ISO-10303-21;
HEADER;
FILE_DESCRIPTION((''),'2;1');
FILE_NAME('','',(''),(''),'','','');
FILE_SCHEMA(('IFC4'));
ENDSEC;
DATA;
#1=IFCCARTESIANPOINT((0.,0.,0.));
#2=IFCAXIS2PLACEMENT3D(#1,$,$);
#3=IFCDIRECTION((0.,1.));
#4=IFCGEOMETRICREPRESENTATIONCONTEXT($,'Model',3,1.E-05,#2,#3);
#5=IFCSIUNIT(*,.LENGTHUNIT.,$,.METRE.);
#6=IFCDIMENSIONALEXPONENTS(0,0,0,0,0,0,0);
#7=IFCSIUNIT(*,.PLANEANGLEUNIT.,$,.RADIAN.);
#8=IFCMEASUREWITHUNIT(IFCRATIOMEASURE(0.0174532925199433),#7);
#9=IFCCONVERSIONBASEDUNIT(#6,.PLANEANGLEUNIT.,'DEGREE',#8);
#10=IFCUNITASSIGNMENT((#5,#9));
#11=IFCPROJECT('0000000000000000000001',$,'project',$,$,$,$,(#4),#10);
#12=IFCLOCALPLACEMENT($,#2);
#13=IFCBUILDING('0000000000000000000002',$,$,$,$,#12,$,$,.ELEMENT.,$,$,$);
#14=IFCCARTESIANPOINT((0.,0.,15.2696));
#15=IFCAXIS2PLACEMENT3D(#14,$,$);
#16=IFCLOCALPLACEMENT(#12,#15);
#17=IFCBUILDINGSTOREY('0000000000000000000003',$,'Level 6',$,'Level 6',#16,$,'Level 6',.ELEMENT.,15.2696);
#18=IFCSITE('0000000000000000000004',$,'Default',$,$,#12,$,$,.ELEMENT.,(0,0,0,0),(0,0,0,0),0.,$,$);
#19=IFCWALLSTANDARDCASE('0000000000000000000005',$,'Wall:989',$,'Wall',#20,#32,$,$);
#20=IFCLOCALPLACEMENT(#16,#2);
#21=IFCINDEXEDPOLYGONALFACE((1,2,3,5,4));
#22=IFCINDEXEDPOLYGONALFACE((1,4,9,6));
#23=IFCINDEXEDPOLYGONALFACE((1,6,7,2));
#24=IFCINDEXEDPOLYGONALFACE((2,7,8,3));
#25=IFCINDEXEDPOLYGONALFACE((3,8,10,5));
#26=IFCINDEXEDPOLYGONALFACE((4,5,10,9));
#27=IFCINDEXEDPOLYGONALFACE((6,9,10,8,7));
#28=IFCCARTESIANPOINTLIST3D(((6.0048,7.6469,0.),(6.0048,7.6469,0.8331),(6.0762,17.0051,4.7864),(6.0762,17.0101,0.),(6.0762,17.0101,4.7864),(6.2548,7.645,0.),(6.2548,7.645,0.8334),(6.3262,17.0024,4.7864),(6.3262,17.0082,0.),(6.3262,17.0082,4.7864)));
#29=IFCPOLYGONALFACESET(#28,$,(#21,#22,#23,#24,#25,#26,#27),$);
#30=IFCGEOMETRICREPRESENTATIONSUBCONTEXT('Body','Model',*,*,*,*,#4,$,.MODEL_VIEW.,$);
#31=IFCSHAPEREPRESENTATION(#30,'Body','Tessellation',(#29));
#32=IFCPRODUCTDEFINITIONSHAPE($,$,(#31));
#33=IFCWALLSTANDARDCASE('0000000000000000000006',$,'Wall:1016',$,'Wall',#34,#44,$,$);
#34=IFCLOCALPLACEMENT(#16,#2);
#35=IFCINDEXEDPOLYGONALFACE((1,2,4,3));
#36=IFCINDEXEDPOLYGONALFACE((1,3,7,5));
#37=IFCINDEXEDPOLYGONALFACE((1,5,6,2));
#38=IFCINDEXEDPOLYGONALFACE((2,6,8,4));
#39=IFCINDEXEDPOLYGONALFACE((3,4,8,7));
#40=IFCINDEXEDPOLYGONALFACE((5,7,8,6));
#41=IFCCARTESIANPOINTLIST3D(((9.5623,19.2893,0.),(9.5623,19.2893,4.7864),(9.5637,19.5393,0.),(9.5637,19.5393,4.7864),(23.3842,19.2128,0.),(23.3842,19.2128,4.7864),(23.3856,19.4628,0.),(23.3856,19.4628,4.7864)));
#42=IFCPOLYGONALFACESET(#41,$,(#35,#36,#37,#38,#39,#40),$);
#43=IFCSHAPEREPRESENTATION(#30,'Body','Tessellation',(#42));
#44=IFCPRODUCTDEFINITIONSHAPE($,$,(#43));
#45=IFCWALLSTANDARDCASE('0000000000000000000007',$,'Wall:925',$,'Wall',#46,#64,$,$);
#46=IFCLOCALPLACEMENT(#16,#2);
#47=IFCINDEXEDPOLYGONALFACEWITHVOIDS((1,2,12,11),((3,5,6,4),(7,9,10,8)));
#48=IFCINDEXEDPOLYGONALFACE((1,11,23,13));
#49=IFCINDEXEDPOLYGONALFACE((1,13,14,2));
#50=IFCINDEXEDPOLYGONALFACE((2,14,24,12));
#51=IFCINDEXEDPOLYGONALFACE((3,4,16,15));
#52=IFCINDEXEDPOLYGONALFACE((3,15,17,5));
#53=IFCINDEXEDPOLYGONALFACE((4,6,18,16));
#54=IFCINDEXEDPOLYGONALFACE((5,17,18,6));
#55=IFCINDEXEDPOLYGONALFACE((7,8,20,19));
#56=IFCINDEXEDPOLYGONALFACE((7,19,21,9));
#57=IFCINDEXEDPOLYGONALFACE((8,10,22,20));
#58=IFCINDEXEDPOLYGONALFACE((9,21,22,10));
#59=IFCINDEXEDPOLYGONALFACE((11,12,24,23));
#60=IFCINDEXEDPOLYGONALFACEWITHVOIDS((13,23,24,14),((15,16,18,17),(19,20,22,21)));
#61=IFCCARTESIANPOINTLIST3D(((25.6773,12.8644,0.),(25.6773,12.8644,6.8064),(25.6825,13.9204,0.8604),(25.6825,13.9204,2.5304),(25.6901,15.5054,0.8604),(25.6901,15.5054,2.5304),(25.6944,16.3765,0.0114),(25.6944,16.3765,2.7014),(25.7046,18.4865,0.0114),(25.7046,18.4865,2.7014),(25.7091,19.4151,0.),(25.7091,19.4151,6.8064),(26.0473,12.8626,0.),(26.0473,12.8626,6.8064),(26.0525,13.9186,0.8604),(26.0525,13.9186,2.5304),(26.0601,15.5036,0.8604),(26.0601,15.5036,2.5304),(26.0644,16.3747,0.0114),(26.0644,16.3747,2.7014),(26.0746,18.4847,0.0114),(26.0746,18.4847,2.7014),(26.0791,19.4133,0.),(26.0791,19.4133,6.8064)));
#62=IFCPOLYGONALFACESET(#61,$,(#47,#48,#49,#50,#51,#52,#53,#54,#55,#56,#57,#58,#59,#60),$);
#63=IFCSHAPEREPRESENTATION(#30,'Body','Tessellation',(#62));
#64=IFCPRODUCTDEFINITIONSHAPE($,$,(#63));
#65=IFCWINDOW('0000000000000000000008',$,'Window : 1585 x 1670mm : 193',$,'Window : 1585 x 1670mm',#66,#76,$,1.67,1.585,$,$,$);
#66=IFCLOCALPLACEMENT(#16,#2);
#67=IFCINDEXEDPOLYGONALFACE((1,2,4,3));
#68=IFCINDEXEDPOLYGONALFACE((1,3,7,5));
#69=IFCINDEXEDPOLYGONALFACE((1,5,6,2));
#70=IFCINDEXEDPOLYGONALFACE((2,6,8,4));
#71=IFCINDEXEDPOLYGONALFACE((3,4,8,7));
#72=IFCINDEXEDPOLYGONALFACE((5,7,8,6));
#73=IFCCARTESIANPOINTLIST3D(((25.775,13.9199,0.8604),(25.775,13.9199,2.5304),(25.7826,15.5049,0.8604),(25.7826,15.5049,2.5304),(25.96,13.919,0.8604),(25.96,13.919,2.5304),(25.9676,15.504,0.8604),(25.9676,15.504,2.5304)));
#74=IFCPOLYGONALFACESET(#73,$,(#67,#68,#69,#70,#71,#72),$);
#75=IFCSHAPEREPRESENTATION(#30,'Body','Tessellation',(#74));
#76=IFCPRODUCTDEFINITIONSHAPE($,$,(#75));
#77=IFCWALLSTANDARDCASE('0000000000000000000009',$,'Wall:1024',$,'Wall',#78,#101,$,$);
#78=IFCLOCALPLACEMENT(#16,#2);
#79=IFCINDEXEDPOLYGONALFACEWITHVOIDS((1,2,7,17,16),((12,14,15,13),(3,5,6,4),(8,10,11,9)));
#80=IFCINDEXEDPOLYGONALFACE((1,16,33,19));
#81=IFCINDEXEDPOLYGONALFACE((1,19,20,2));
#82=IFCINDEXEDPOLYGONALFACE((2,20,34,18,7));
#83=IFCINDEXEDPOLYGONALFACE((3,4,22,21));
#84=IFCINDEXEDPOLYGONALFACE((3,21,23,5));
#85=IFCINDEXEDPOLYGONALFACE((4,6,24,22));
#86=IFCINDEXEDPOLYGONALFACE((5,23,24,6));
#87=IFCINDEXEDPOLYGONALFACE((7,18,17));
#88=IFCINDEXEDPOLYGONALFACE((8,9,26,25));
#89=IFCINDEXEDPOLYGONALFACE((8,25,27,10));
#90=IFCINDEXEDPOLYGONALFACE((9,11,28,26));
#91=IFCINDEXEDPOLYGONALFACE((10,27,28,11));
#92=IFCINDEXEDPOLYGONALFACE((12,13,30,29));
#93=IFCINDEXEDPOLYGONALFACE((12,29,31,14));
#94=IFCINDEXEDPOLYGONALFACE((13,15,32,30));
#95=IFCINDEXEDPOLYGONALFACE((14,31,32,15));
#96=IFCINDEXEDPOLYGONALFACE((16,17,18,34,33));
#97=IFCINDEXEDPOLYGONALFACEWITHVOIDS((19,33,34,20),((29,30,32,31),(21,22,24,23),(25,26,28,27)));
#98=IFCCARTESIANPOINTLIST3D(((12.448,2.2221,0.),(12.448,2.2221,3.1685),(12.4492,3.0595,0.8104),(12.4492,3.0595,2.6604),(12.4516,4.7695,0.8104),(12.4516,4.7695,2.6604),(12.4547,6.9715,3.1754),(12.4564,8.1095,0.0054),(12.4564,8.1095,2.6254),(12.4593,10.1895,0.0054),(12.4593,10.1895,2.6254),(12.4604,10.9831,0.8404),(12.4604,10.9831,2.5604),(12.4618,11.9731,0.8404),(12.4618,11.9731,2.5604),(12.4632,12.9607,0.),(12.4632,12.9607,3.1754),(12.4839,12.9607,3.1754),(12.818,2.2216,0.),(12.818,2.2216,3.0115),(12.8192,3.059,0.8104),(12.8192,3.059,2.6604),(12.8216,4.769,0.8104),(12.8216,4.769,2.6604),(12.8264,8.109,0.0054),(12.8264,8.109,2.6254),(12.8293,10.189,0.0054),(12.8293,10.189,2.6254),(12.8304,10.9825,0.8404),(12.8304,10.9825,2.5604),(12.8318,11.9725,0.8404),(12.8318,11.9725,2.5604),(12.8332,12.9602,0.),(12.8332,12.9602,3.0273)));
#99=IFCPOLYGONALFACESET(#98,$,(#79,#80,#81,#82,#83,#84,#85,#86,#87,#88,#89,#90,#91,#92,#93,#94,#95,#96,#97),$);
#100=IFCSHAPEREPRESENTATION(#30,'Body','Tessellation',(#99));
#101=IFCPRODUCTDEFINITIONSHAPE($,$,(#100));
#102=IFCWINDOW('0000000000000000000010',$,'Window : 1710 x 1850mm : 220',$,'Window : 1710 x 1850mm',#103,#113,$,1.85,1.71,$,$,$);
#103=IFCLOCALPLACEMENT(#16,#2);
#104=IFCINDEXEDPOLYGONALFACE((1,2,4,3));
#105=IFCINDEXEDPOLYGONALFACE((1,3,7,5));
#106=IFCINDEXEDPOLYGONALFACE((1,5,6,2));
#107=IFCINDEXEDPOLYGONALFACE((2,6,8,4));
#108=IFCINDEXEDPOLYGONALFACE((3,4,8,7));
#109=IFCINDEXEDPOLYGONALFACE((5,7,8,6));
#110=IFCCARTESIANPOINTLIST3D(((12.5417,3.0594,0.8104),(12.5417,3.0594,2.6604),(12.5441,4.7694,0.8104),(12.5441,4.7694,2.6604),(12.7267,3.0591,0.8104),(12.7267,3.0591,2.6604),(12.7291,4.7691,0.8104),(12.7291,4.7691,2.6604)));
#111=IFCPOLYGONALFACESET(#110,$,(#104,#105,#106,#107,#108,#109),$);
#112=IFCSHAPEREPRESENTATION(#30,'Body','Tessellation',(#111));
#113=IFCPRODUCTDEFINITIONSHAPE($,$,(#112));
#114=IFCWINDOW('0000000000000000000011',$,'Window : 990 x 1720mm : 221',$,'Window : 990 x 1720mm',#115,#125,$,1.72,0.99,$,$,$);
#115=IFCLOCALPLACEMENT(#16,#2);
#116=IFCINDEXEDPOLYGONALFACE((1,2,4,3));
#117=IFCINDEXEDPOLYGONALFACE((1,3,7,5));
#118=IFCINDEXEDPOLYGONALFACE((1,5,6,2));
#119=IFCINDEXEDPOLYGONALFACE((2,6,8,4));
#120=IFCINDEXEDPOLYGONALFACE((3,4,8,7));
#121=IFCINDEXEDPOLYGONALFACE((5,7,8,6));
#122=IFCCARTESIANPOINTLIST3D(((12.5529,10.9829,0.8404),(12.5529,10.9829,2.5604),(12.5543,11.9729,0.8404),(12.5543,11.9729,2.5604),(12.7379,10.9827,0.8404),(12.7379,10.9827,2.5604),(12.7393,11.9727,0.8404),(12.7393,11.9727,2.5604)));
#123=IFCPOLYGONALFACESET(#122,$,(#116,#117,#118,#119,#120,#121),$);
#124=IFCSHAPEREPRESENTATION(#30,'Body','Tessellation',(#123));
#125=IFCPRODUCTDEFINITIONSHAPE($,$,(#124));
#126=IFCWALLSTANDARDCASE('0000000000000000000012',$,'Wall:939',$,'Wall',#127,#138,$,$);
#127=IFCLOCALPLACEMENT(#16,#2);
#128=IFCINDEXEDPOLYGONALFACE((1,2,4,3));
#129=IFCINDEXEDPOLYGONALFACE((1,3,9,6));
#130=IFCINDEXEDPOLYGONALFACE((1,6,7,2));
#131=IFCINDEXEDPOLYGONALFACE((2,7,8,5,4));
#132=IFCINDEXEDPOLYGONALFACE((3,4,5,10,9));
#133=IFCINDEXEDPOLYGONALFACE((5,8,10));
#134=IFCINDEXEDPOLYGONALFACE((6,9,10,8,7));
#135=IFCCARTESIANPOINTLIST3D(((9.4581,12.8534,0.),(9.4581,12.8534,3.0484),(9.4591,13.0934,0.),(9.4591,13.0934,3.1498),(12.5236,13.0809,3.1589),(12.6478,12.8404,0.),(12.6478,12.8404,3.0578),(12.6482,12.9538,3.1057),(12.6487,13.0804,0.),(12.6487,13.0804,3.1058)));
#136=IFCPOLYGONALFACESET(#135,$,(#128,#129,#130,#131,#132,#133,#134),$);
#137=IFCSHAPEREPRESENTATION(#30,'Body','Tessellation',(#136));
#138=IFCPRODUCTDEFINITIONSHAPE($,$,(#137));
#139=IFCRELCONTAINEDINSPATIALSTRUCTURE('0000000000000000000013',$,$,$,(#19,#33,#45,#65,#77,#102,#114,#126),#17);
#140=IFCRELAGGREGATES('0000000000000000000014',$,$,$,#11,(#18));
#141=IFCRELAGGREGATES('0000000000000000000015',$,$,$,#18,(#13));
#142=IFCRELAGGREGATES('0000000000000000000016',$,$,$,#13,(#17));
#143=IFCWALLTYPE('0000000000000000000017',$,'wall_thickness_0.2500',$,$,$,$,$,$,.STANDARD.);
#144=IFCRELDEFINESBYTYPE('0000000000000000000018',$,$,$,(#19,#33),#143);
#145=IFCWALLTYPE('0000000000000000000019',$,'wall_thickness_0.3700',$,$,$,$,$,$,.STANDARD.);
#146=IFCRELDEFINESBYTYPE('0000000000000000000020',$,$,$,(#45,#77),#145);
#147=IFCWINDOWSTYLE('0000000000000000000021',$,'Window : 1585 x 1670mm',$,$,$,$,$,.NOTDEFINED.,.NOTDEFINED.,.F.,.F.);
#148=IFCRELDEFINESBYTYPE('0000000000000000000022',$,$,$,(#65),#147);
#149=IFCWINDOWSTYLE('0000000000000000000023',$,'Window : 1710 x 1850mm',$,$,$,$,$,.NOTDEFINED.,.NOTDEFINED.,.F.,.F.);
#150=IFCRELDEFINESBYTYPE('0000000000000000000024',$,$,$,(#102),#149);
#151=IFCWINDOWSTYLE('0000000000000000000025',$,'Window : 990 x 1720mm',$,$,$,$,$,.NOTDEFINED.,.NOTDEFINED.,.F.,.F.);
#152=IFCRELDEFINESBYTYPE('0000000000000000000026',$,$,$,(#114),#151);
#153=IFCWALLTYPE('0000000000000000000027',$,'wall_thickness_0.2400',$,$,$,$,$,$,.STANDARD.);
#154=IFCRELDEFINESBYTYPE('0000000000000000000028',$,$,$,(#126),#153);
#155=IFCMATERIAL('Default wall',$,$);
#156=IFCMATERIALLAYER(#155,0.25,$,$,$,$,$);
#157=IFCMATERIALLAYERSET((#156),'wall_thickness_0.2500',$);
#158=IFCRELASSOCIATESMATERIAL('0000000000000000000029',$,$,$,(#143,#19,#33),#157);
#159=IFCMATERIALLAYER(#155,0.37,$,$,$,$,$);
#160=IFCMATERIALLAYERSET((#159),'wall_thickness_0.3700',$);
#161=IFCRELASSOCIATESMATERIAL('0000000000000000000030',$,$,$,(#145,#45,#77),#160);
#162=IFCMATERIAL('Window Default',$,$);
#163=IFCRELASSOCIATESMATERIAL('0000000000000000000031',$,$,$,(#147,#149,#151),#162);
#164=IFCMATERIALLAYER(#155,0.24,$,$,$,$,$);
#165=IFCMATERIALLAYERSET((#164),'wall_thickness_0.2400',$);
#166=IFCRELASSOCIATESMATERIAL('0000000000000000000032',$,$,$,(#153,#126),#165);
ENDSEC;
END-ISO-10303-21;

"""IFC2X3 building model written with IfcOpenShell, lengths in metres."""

from ifc_helpers import new_model, entity, si_unit, converted_unit, direction, frame, frame_2d, origin, origin_2d_with_axis, place, context, subcontext, project, spatial, polyline, rectangle, outline, extrude, clip, halfspace, source, transform, mapped, material, layer, layer_set, layer_usage, type_object, type_shapes, element, fill, save


model = new_model("IFC2X3")

# Units and contexts
model_context = context("Model", 3, precision=1e-05, world=origin(), true_north=direction((0.0, 1.0)))
body_context = subcontext(model_context, "Body", "Model", "MODEL_VIEW")
ifc_project = project(units=[si_unit("LENGTHUNIT", "METRE"), converted_unit("PLANEANGLEUNIT", "DEGREE", entity("IfcRatioMeasure", 0.0174532925199433), si_unit("PLANEANGLEUNIT", "RADIAN"), dimensions=[0, 0, 0, 0, 0, 0, 0])], contexts=[model_context])

# Site, building, storey
placement = place(None, origin())
site = spatial("IfcSite", under=ifc_project, at=placement, Name="Default", CompositionType="ELEMENT", RefLatitude=(0, 0, 0, 0), RefLongitude=(0, 0, 0, 0), RefElevation=0.0)
building = spatial("IfcBuilding", under=site, at=placement, CompositionType="ELEMENT")
storey_placement = place(placement, frame((0.0, 0.0, 15.2696)))
storey = spatial("IfcBuildingStorey", under=building, at=storey_placement, Name="Level 6", ObjectType="Level 6", LongName="Level 6", CompositionType="ELEMENT", Elevation=15.2696)

# Walls
ifc_material_1 = material(Name="Default wall")
ifc_layer_1 = layer(ifc_material_1, 0.25)
ifc_layer_set_1 = layer_set([ifc_layer_1], Name="wall_thickness_0.2500")
ifc_layer_usage_1 = layer_usage(ifc_layer_set_1, "AXIS2", "POSITIVE", -0.125)
wall_type_1 = type_object("IfcWallType", Name="wall_thickness_0.2500", PredefinedType="STANDARD", material=ifc_layer_set_1)
wall_1_placement = place(storey_placement, frame((6.2012, 17.0092, 0.0), z_axis=(0.0, 0.0, 1.0), x_axis=(-0.007623, -0.999971, 0.0)))
element("IfcWallStandardCase", 1, at=wall_1_placement, inside=storey, type_object=wall_type_1, material=ifc_layer_usage_1, Name="Wall:989", ObjectType="Wall", context=body_context, shape_type="Clipping", body=[
    clip(clip(extrude(outline(polyline([(9.3635, -0.125), (9.3635, 0.125), (0.0, 0.125), (0.0, -0.125), (9.3635, -0.125)])), origin(), (0.0, 0.0, 1.0), 4.7864), halfspace(frame((-60.2827, 7.4216, 2.6304), z_axis=(-0.001073, 0.390504, 0.920601), x_axis=(0.003026, -0.920596, 0.390505)), False)), halfspace(frame((-2.4456, -18.2536, 5.7956), z_axis=(0.389138, -0.001325, 0.921178), x_axis=(0.002195, 0.999997, 0.000511)), False)),
])
wall_2_placement = place(storey_placement, frame((9.563, 19.4143, 0.0), z_axis=(0.0, 0.0, 1.0), x_axis=(0.999985, -0.005533, 0.0)))
element("IfcWallStandardCase", 2, at=wall_2_placement, inside=storey, type_object=wall_type_1, material=ifc_layer_usage_1, Name="Wall:1016", ObjectType="Wall", context=body_context, shape_type="Clipping", body=[
    clip(extrude(outline(polyline([(13.8221, -0.125), (13.8221, 0.125), (0.0, 0.125), (0.0, -0.125), (13.8221, -0.125)])), origin(), (0.0, 0.0, 1.0), 4.7864), halfspace(frame((14.8176, -0.096, 5.8902), z_axis=(0.001197, 0.389103, 0.921193), x_axis=(-0.999991, 0.004285, -0.000511)), False)),
])

# Wall, openings, window
ifc_layer_2 = layer(ifc_material_1, 0.37)
ifc_layer_set_2 = layer_set([ifc_layer_2], Name="wall_thickness_0.3700")
ifc_layer_usage_2 = layer_usage(ifc_layer_set_2, "AXIS2", "POSITIVE", -0.185)
wall_type_2 = type_object("IfcWallType", Name="wall_thickness_0.3700", PredefinedType="STANDARD", material=ifc_layer_set_2)
wall_3_placement = place(storey_placement, frame((25.8941, 19.4142, 0.0), z_axis=(0.0, 0.0, 1.0), x_axis=(-0.004844, -0.999988, 0.0)))
wall_3 = element("IfcWallStandardCase", 3, at=wall_3_placement, inside=storey, type_object=wall_type_2, material=ifc_layer_usage_2, Name="Wall:925", ObjectType="Wall", context=body_context, shape_type="SweptSolid", body=[
    extrude(outline(polyline([(6.5507, -0.185), (6.5507, 0.185), (0.0, 0.185), (0.0, -0.185), (6.5507, -0.185)])), origin(), (0.0, 0.0, 1.0), 6.8064),
])
opening_1_placement = place(wall_3_placement, frame((0.9286, -0.185, 0.0114)))
element("IfcOpeningElement", 4, at=opening_1_placement, cuts=wall_3, ObjectType="Opening", context=body_context, shape_type="SweptSolid", body=[
    extrude(rectangle(XDim=2.11, YDim=2.69, at=frame_2d((1.345, 1.055), x_axis=(0.0, 1.0))), frame((0.0, 0.0, 0.0), z_axis=(0.0, 1.0, 0.0), x_axis=(0.0, 0.0, 1.0)), (0.0, 0.0, 1.0), 0.37),
])
opening_2_placement = place(wall_3_placement, frame((3.9097, -0.185, 0.8604)))
opening_2 = element("IfcOpeningElement", 5, at=opening_2_placement, cuts=wall_3, ObjectType="Opening", context=body_context, shape_type="SweptSolid", body=[
    extrude(rectangle(XDim=1.585, YDim=1.67, at=frame_2d((0.835, 0.7925), x_axis=(0.0, 1.0))), frame((0.0, 0.0, 0.0), z_axis=(0.0, 1.0, 0.0), x_axis=(0.0, 0.0, 1.0)), (0.0, 0.0, 1.0), 0.37),
])
ifc_material_2 = material(Name="Window Default")
window_style_1 = type_object("IfcWindowStyle", Name="Window : 1585 x 1670mm", ConstructionType="NOTDEFINED", OperationType="NOTDEFINED", ParameterTakesPrecedence=False, Sizeable=False, material=ifc_material_2)
shared_shape_1 = source(origin(), body_context, "Body", "SweptSolid", [
    extrude(rectangle(XDim=0.185, YDim=1.585, at=origin_2d_with_axis()), frame((0.7925, 0.185, 0.0), z_axis=(0.0, 0.0, 1.0), x_axis=(0.0, 1.0, 0.0)), (0.0, 0.0, 1.0), 1.67),
])
type_shapes(window_style_1, [shared_shape_1])
window_1_placement = place(opening_2_placement, origin())
window_1 = element("IfcWindow", 6, at=window_1_placement, inside=storey, type_object=window_style_1, Name="Window : 1585 x 1670mm : 193", ObjectType="Window : 1585 x 1670mm", OverallHeight=1.67, OverallWidth=1.585, context=body_context, shape_type="MappedRepresentation", body=[
    mapped(shared_shape_1, transform((0.0, 0.0, 0.0), scale=1.0)),
])
fill(opening_2, window_1)

# Wall, openings, windows
wall_4_placement = place(storey_placement, frame((12.6482, 12.9604, 0.0), z_axis=(0.0, 0.0, 1.0), x_axis=(-0.001421, -0.999999, 0.0)))
wall_4 = element("IfcWallStandardCase", 7, at=wall_4_placement, inside=storey, type_object=wall_type_2, material=ifc_layer_usage_2, Name="Wall:1024", ObjectType="Wall", context=body_context, shape_type="Clipping", body=[
    clip(extrude(outline(polyline([(10.7386, -0.185), (10.7386, 0.185), (0.0, 0.185), (0.0, -0.185), (10.7386, -0.185)])), origin(), (0.0, 0.0, 1.0), 3.1754), halfspace(frame((-64.2751, 1.3426, 2.6304), z_axis=(0.001349, 0.390503, 0.920601), x_axis=(-0.002684, -0.920597, 0.390505)), False)),
])
opening_3_placement = place(wall_4_placement, frame((2.7712, -0.185, 0.0054)))
element("IfcOpeningElement", 8, at=opening_3_placement, cuts=wall_4, ObjectType="Opening", context=body_context, shape_type="SweptSolid", body=[
    extrude(rectangle(XDim=2.08, YDim=2.62, at=frame_2d((1.31, 1.04), x_axis=(0.0, 1.0))), frame((0.0, 0.0, 0.0), z_axis=(0.0, 1.0, 0.0), x_axis=(0.0, 0.0, 1.0)), (0.0, 0.0, 1.0), 0.37),
])
opening_4_placement = place(wall_4_placement, frame((8.1912, -0.185, 0.8104)))
opening_4 = element("IfcOpeningElement", 9, at=opening_4_placement, cuts=wall_4, ObjectType="Opening", context=body_context, shape_type="SweptSolid", body=[
    extrude(rectangle(XDim=1.71, YDim=1.85, at=frame_2d((0.925, 0.855), x_axis=(0.0, 1.0))), frame((0.0, 0.0, 0.0), z_axis=(0.0, 1.0, 0.0), x_axis=(0.0, 0.0, 1.0)), (0.0, 0.0, 1.0), 0.37),
])
opening_5_placement = place(wall_4_placement, frame((0.9876, -0.185, 0.8404)))
opening_5 = element("IfcOpeningElement", 10, at=opening_5_placement, cuts=wall_4, ObjectType="Opening", context=body_context, shape_type="SweptSolid", body=[
    extrude(rectangle(XDim=0.99, YDim=1.72, at=frame_2d((0.86, 0.495), x_axis=(0.0, 1.0))), frame((0.0, 0.0, 0.0), z_axis=(0.0, 1.0, 0.0), x_axis=(0.0, 0.0, 1.0)), (0.0, 0.0, 1.0), 0.37),
])
window_style_2 = type_object("IfcWindowStyle", Name="Window : 1710 x 1850mm", ConstructionType="NOTDEFINED", OperationType="NOTDEFINED", ParameterTakesPrecedence=False, Sizeable=False, material=ifc_material_2)
shared_shape_2 = source(origin(), body_context, "Body", "SweptSolid", [
    extrude(rectangle(XDim=0.185, YDim=1.71, at=origin_2d_with_axis()), frame((0.855, 0.185, 0.0), z_axis=(0.0, 0.0, 1.0), x_axis=(0.0, 1.0, 0.0)), (0.0, 0.0, 1.0), 1.85),
])
type_shapes(window_style_2, [shared_shape_2])
window_2_placement = place(opening_4_placement, origin())
window_2 = element("IfcWindow", 11, at=window_2_placement, inside=storey, type_object=window_style_2, Name="Window : 1710 x 1850mm : 220", ObjectType="Window : 1710 x 1850mm", OverallHeight=1.85, OverallWidth=1.71, context=body_context, shape_type="MappedRepresentation", body=[
    mapped(shared_shape_2, transform((0.0, 0.0, 0.0), scale=1.0)),
])
fill(opening_4, window_2)
window_style_3 = type_object("IfcWindowStyle", Name="Window : 990 x 1720mm", ConstructionType="NOTDEFINED", OperationType="NOTDEFINED", ParameterTakesPrecedence=False, Sizeable=False, material=ifc_material_2)
shared_shape_3 = source(origin(), body_context, "Body", "SweptSolid", [
    extrude(rectangle(XDim=0.185, YDim=0.99, at=origin_2d_with_axis()), frame((0.495, 0.185, 0.0), z_axis=(0.0, 0.0, 1.0), x_axis=(0.0, 1.0, 0.0)), (0.0, 0.0, 1.0), 1.72),
])
type_shapes(window_style_3, [shared_shape_3])
window_3_placement = place(opening_5_placement, origin())
window_3 = element("IfcWindow", 12, at=window_3_placement, inside=storey, type_object=window_style_3, Name="Window : 990 x 1720mm : 221", ObjectType="Window : 990 x 1720mm", OverallHeight=1.72, OverallWidth=0.99, context=body_context, shape_type="MappedRepresentation", body=[
    mapped(shared_shape_3, transform((0.0, 0.0, 0.0), scale=1.0)),
])
fill(opening_5, window_3)

# Wall
ifc_layer_3 = layer(ifc_material_1, 0.24)
ifc_layer_set_3 = layer_set([ifc_layer_3], Name="wall_thickness_0.2400")
ifc_layer_usage_3 = layer_usage(ifc_layer_set_3, "AXIS2", "POSITIVE", -0.12)
wall_type_3 = type_object("IfcWallType", Name="wall_thickness_0.2400", PredefinedType="STANDARD", material=ifc_layer_set_3)
wall_5_placement = place(storey_placement, frame((9.4586, 12.9734, 0.0), z_axis=(0.0, 0.0, 1.0), x_axis=(0.999992, -0.004056, 0.0)))
element("IfcWallStandardCase", 13, at=wall_5_placement, inside=storey, type_object=wall_type_3, material=ifc_layer_usage_3, Name="Wall:939", ObjectType="Wall", context=body_context, shape_type="Clipping", body=[
    clip(clip(extrude(outline(polyline([(3.1897, -0.12), (3.1897, 0.12), (0.0, 0.12), (0.0, -0.12), (3.1897, -0.12)])), origin(), (0.0, 0.0, 1.0), 3.2504), halfspace(frame((4.3628, 64.2784, 2.6304), z_axis=(0.390505, -0.00032, 0.920601), x_axis=(-0.920601, 0.000258, 0.390505)), False)), halfspace(frame((-21.5185, 6.5332, 5.7956), z_axis=(-0.002713, -0.389131, 0.921178), x_axis=(0.999983, -0.005763, 0.000511)), False)),
])

save(model, "model.ifc")
